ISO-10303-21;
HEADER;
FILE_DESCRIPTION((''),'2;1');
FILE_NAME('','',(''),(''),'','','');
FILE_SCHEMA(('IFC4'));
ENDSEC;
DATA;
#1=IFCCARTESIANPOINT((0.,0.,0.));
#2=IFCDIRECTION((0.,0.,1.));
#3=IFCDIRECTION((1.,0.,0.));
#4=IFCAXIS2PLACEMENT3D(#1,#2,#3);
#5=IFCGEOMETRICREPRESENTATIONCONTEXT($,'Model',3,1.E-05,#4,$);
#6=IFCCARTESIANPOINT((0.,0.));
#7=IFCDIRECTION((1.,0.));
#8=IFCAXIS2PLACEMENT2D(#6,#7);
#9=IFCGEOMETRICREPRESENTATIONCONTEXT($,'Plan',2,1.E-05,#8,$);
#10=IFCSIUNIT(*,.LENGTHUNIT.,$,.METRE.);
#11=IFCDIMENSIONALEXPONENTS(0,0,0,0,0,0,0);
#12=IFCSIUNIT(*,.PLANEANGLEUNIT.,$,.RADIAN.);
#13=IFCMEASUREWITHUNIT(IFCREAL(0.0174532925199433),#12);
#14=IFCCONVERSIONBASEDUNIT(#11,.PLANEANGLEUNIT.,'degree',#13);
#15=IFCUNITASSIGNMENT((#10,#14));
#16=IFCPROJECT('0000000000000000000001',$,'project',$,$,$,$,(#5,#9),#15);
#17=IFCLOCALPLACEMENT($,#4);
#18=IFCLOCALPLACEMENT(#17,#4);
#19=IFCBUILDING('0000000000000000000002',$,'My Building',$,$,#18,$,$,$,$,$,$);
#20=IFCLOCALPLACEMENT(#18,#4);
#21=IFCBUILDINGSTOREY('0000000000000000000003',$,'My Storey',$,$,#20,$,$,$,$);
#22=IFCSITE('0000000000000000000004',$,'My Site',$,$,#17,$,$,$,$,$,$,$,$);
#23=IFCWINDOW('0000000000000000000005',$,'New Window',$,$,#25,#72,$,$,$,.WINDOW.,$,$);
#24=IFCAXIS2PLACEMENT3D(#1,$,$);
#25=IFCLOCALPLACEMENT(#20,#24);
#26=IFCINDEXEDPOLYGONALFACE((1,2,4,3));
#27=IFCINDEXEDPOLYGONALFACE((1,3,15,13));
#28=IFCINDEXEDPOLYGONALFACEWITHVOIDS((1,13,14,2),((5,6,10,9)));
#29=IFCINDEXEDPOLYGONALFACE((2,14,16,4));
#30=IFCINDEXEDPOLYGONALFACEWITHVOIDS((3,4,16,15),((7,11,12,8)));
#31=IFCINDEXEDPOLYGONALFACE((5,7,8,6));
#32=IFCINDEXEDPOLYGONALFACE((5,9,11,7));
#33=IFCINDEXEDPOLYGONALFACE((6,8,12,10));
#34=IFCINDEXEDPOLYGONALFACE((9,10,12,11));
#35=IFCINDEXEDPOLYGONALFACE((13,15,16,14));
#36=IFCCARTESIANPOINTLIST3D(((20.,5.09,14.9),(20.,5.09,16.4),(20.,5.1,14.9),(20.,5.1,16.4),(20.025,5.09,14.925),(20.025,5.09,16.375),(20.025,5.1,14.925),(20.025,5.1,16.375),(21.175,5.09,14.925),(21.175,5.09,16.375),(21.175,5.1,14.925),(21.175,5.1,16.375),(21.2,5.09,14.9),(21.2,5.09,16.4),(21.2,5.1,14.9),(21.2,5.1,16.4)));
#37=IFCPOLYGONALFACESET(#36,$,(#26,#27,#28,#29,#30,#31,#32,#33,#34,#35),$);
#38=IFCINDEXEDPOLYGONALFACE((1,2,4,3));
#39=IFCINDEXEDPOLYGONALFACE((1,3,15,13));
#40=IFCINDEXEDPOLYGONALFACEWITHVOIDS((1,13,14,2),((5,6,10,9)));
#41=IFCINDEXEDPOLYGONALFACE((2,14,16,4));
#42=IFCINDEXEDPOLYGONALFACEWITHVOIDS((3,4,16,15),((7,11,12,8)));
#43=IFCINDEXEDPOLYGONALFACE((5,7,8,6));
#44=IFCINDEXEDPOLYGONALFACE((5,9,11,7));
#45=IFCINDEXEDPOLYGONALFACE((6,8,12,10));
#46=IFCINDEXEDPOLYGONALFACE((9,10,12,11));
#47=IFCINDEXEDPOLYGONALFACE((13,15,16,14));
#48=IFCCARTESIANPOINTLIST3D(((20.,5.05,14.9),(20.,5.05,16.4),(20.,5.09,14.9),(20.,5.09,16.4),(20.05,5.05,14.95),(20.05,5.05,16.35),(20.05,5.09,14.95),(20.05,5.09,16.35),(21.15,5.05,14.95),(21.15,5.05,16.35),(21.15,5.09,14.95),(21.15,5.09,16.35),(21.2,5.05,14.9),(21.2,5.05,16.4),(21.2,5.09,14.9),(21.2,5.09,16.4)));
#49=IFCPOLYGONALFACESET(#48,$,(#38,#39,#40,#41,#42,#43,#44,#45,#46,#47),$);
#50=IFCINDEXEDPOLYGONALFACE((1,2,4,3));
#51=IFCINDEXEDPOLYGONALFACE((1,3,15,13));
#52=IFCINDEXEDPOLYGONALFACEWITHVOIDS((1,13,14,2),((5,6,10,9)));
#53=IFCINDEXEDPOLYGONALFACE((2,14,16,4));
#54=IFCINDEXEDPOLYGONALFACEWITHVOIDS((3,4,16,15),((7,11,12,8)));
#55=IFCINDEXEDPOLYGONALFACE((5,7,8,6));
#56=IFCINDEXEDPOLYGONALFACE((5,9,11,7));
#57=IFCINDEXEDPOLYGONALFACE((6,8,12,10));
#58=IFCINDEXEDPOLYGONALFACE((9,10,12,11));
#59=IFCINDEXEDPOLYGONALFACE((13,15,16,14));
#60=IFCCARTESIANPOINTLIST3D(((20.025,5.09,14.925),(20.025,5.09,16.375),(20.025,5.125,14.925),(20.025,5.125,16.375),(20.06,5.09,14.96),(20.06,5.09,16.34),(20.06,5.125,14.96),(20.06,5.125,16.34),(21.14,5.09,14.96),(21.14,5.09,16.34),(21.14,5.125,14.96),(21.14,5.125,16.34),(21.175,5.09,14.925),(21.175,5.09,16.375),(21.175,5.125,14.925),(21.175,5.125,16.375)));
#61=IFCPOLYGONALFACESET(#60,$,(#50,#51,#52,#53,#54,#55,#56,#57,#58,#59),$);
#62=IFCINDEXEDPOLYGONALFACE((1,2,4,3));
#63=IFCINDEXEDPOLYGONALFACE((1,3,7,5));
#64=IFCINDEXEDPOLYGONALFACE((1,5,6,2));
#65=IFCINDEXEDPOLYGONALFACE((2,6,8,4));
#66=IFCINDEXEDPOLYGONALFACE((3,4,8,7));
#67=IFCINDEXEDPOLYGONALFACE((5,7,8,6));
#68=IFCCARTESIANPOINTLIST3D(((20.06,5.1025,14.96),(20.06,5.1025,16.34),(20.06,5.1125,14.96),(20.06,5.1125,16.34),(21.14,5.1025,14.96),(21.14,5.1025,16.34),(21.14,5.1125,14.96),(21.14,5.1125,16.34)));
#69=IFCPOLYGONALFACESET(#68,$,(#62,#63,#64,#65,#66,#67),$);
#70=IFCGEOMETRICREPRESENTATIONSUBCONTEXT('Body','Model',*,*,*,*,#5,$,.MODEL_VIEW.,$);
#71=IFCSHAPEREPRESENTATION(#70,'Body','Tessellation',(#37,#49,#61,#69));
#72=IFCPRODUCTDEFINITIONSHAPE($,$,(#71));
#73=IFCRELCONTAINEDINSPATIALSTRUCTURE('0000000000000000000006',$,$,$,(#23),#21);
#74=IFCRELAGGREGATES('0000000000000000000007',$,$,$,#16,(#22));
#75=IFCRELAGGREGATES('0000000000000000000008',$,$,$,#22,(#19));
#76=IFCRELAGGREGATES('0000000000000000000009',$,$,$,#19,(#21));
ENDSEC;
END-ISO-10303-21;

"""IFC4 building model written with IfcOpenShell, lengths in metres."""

from ifc_helpers import new_model, entity, si_unit, converted_unit, frame, origin_with_axes, origin_2d_with_axis, place, context, subcontext, project, spatial, line, indexed_curve, outline, extrude, element, save


model = new_model("IFC4")

# Units and contexts
model_context = context("Model", 3, precision=1e-05, world=origin_with_axes())
plan_context = context("Plan", 2, precision=1e-05, world=origin_2d_with_axis())
body_context = subcontext(model_context, "Body", "Model", "MODEL_VIEW")
ifc_project = project(units=[si_unit("LENGTHUNIT", "METRE"), converted_unit("PLANEANGLEUNIT", "degree", entity("IfcReal", 0.0174532925199433), si_unit("PLANEANGLEUNIT", "RADIAN"), dimensions=[0, 0, 0, 0, 0, 0, 0])], contexts=[model_context, plan_context])

# Site, building, storey
site_placement = place(None, origin_with_axes())
site = spatial("IfcSite", under=ifc_project, at=site_placement, Name="My Site")
building_placement = place(site_placement, origin_with_axes())
building = spatial("IfcBuilding", under=site, at=building_placement, Name="My Building")
storey_placement = place(building_placement, origin_with_axes())
storey = spatial("IfcBuildingStorey", under=building, at=storey_placement, Name="My Storey")

# Window
for number, where, z_axis, x_axis, name in (
    (1, (20.0, 5.0, 14.9), (0.0, 0.0, 1.0), (1.0, 0.0, 0.0), "New Window"),
):
    element("IfcWindow", number, at=place(storey_placement, frame(where, z_axis=z_axis, x_axis=x_axis)), inside=storey, Name=name, PredefinedType="WINDOW", context=body_context, shape_type="SweptSolid", body=[
        extrude(outline(indexed_curve([(0.0, 0.0), (1.2, 0.0), (1.2, 1.5), (0.0, 1.5)], segments=[line(1, 2, 3, 4, 1)]), holes=[indexed_curve([(0.025, 0.025), (1.175, 0.025), (1.175, 1.475), (0.025, 1.475)], segments=[line(1, 2, 3, 4, 1)])]), frame((0.0, 0.09, 0.0), z_axis=(0.0, -1.0, 0.0), x_axis=(1.0, 0.0, 0.0)), (0.0, 0.0, -1.0), 0.01),
        extrude(outline(indexed_curve([(0.0, 0.0), (1.2, 0.0), (1.2, 1.5), (0.0, 1.5)], segments=[line(1, 2, 3, 4, 1)]), holes=[indexed_curve([(0.05, 0.05), (1.15, 0.05), (1.15, 1.45), (0.05, 1.45)], segments=[line(1, 2, 3, 4, 1)])]), frame((0.0, 0.05, 0.0), z_axis=(0.0, -1.0, 0.0), x_axis=(1.0, 0.0, 0.0)), (0.0, 0.0, -1.0), 0.04),
        extrude(outline(indexed_curve([(0.0, 0.0), (1.15, 0.0), (1.15, 1.45), (0.0, 1.45)], segments=[line(1, 2, 3, 4, 1)]), holes=[indexed_curve([(0.035, 0.035), (1.115, 0.035), (1.115, 1.415), (0.035, 1.415)], segments=[line(1, 2, 3, 4, 1)])]), frame((0.025, 0.09, 0.025), z_axis=(0.0, -1.0, 0.0), x_axis=(1.0, 0.0, 0.0)), (0.0, 0.0, -1.0), 0.035),
        extrude(outline(indexed_curve([(0.035, 0.035), (1.115, 0.035), (1.115, 1.415), (0.035, 1.415)], segments=[line(1, 2, 3, 4, 1)])), frame((0.025, 0.1025, 0.025), z_axis=(0.0, -1.0, 0.0), x_axis=(1.0, 0.0, 0.0)), (0.0, 0.0, -1.0), 0.01),
    ])

save(model, "model.ifc")
